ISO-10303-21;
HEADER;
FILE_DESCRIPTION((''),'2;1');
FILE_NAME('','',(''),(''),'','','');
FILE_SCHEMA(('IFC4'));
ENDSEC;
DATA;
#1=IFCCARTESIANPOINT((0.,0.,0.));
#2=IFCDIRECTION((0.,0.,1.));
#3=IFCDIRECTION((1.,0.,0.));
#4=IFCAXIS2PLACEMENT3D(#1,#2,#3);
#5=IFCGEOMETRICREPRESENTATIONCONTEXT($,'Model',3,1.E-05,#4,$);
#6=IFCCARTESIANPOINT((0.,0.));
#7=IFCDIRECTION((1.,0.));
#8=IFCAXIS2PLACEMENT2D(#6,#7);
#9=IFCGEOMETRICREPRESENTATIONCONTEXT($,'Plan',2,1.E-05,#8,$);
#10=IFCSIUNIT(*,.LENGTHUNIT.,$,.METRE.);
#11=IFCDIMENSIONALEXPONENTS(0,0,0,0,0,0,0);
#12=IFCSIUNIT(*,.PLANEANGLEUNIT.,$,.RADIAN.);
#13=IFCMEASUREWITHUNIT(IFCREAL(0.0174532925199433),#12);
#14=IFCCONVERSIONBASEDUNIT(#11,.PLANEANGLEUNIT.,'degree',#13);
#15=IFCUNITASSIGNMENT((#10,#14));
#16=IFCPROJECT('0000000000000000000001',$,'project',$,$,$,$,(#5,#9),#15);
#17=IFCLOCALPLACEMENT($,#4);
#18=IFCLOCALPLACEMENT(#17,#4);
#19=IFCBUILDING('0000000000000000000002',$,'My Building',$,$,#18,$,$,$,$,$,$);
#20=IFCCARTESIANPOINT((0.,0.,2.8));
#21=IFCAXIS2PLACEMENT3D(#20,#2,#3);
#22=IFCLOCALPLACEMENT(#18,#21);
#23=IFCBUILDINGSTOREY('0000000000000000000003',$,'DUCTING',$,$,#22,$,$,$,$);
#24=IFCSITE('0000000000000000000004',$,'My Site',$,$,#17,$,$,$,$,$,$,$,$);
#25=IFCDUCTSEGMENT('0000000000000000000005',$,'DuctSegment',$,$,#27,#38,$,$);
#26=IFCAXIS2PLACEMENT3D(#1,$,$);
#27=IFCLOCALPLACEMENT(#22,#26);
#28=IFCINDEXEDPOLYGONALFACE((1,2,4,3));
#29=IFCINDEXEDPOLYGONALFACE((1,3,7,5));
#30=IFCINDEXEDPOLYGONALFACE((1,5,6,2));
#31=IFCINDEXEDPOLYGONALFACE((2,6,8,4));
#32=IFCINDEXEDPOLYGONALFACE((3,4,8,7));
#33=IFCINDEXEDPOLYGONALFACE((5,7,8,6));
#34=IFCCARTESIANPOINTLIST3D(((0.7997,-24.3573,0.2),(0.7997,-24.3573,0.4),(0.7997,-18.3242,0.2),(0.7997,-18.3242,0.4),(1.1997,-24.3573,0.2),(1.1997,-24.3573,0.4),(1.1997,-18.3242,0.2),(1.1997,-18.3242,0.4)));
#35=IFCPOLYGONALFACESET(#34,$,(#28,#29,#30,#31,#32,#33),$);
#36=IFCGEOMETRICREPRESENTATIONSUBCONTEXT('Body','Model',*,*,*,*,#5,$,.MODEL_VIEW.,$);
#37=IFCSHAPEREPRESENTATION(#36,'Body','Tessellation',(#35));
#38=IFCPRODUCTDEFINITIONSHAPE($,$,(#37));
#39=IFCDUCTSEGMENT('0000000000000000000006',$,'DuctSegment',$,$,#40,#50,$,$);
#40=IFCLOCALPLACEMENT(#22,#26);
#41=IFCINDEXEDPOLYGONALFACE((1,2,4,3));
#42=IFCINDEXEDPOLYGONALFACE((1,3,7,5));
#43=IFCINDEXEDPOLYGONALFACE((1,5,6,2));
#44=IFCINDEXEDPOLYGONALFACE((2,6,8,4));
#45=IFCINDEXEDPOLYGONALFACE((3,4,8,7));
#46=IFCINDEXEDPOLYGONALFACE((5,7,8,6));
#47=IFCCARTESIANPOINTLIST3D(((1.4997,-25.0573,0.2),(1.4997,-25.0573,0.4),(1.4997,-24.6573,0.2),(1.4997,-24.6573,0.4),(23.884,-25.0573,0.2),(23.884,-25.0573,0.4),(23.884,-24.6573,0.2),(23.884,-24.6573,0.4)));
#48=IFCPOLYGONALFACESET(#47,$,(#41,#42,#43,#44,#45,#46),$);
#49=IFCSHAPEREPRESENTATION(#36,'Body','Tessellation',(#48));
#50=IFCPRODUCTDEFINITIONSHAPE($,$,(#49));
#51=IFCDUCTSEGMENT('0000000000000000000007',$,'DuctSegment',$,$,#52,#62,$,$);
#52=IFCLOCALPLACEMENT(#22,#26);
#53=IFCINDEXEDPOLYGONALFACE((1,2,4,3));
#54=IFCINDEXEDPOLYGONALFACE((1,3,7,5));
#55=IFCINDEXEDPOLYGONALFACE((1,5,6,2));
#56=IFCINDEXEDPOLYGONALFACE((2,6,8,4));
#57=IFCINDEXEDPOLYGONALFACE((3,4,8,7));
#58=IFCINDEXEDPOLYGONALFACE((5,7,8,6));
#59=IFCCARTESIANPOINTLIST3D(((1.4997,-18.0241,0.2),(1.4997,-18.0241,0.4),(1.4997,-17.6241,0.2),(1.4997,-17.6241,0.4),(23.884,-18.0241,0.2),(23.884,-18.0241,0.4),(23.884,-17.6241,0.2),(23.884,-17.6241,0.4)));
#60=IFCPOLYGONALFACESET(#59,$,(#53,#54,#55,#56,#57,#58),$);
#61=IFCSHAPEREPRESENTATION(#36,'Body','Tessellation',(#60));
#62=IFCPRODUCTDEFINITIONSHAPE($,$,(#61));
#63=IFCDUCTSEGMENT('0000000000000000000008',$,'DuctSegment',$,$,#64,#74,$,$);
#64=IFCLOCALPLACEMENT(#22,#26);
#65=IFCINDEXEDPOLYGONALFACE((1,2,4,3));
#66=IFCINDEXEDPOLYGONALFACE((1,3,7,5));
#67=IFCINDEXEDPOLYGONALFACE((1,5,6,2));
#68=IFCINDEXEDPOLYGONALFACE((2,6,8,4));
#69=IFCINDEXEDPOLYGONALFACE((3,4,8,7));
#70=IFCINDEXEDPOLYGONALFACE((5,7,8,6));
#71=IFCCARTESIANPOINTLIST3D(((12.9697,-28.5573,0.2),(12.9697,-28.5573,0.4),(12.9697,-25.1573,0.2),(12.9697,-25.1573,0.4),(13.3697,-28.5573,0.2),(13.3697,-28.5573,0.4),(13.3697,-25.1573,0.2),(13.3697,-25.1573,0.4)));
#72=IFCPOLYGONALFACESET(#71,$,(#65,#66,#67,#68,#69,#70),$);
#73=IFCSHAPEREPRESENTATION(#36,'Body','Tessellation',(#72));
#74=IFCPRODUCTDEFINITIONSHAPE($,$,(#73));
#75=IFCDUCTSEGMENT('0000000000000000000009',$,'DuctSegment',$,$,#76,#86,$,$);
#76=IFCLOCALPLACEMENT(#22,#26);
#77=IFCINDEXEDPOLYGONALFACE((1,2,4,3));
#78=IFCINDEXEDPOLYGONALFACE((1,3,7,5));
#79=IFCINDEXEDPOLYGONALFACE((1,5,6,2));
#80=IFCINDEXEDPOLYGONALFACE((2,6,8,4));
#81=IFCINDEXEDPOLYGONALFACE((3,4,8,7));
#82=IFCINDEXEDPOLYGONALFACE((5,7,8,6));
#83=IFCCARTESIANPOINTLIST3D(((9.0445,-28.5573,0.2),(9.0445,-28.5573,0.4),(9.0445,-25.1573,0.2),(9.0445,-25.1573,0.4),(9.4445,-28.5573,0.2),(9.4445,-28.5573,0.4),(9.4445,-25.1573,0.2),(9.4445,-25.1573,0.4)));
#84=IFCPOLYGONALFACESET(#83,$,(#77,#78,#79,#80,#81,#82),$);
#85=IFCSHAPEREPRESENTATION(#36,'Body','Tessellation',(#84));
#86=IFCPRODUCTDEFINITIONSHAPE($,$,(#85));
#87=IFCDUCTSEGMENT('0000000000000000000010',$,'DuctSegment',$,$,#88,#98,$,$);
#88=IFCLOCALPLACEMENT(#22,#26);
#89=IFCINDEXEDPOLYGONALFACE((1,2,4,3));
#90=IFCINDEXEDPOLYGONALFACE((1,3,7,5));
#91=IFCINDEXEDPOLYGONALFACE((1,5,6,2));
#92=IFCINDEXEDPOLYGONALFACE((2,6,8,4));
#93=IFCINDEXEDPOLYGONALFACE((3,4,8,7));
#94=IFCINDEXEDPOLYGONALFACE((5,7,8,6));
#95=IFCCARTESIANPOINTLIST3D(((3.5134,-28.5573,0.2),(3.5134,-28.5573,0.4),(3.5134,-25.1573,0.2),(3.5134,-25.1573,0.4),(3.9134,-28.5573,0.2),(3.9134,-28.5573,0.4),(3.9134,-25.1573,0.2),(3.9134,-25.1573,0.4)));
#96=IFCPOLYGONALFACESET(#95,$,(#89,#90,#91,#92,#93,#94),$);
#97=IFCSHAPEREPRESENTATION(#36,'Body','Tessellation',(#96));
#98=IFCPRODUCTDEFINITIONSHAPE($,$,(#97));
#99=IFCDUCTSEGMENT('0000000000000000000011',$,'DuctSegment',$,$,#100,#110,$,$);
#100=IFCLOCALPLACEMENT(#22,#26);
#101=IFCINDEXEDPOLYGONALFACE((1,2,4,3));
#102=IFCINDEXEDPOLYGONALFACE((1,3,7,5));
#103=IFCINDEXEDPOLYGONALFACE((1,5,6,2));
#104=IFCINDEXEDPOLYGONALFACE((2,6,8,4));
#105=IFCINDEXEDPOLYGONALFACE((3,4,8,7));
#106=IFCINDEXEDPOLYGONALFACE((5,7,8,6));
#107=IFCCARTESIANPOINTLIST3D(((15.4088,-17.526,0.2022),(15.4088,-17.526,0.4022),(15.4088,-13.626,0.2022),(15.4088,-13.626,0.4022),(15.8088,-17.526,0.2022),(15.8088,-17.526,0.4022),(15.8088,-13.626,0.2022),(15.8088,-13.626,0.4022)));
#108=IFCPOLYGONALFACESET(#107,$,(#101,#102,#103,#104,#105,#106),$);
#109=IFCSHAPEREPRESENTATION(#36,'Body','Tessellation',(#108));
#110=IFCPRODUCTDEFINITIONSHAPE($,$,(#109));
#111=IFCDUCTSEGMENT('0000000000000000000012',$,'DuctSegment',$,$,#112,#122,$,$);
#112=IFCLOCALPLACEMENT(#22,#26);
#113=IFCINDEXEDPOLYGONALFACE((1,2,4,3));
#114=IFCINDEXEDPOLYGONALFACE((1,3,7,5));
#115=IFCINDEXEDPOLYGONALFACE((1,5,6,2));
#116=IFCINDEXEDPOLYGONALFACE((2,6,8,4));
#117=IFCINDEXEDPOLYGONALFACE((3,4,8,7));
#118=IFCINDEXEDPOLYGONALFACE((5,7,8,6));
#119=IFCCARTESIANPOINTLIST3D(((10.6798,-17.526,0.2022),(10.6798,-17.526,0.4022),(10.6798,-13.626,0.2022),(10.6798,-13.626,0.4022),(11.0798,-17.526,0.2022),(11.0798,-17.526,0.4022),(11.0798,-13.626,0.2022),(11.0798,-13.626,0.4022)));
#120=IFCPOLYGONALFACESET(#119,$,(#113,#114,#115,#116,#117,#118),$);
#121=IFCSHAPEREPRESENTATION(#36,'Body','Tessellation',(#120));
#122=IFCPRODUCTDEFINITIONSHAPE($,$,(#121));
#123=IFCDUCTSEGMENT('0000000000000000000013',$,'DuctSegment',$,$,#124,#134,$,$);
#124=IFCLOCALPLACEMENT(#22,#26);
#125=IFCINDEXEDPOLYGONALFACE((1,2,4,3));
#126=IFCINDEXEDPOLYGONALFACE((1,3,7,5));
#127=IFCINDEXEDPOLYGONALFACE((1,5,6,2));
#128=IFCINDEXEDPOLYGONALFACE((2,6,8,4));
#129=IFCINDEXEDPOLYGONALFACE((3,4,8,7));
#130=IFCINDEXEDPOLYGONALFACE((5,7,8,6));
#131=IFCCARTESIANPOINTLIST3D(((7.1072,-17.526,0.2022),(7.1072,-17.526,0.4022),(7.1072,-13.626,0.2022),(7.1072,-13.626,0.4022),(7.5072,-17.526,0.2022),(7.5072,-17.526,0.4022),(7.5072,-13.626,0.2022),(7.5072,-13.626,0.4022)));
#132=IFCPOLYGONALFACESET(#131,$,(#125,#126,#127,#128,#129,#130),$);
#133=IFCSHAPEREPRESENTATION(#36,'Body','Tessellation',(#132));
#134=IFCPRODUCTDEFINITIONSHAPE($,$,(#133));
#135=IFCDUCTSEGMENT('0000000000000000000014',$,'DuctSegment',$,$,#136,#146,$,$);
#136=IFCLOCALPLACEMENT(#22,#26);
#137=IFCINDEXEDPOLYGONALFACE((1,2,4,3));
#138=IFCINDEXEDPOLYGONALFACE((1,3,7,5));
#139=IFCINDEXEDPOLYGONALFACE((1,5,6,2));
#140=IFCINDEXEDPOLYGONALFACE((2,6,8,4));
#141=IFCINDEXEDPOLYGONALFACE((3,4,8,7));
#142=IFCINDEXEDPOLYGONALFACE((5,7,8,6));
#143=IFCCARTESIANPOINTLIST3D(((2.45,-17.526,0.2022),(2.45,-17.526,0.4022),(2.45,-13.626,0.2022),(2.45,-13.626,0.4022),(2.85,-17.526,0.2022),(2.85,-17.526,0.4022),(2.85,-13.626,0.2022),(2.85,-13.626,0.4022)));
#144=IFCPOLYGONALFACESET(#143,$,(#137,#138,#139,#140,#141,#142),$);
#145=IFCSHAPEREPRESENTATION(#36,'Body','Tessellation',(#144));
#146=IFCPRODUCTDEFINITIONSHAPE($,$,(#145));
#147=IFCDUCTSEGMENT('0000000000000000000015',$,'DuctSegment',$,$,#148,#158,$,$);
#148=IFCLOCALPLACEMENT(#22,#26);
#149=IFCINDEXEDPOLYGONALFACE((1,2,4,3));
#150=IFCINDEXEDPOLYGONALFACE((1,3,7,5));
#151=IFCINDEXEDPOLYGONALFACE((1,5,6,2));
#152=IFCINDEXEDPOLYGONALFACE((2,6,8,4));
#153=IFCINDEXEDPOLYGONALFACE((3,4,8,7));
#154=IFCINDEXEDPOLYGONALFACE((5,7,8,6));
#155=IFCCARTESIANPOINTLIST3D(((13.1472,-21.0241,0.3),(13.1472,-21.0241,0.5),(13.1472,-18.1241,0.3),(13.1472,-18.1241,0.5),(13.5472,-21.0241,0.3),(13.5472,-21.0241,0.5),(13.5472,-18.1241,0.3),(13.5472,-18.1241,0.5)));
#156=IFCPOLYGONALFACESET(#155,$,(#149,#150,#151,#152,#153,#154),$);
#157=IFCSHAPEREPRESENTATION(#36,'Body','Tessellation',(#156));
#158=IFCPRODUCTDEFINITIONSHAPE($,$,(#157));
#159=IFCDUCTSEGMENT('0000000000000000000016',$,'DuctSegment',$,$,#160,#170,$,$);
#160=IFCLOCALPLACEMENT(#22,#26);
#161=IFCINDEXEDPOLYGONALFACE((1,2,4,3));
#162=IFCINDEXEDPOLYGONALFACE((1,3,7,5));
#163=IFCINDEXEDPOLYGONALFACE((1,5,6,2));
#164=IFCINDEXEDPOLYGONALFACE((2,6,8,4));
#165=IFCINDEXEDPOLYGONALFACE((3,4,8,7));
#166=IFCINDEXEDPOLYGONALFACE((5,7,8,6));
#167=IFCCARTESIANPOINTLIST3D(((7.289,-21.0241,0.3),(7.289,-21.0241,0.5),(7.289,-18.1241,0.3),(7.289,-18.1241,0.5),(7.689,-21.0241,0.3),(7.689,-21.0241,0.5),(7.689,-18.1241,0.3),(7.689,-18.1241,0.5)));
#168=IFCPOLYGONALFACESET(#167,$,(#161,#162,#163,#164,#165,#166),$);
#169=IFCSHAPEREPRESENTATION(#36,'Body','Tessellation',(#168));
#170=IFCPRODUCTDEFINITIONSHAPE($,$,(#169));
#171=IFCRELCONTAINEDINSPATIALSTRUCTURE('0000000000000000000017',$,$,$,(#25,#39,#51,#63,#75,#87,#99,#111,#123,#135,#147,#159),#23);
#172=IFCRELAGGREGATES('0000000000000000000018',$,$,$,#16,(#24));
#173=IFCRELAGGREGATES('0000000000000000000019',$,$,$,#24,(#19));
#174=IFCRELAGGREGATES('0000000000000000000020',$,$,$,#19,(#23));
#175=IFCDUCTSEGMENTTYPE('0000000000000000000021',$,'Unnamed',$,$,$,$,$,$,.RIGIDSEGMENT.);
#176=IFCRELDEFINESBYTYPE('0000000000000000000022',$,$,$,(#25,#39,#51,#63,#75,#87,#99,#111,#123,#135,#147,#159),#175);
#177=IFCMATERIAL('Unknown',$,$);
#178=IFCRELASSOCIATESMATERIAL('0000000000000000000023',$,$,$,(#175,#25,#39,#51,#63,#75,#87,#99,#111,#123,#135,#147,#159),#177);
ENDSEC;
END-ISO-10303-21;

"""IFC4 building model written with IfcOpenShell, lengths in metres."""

from ifc_helpers import new_model, entity, si_unit, converted_unit, frame, origin_with_axes, origin_2d_with_axis, place, context, subcontext, project, spatial, rectangle, extrude, material, material_profile, profile_set, profile_usage, type_object, element, save


model = new_model("IFC4")

# Units and contexts
model_context = context("Model", 3, precision=1e-05, world=origin_with_axes())
plan_context = context("Plan", 2, precision=1e-05, world=origin_2d_with_axis())
body_context = subcontext(model_context, "Body", "Model", "MODEL_VIEW")
ifc_project = project(units=[si_unit("LENGTHUNIT", "METRE"), converted_unit("PLANEANGLEUNIT", "degree", entity("IfcReal", 0.0174532925199433), si_unit("PLANEANGLEUNIT", "RADIAN"), dimensions=[0, 0, 0, 0, 0, 0, 0])], contexts=[model_context, plan_context])

# Site, building, storey
site_placement = place(None, origin_with_axes())
site = spatial("IfcSite", under=ifc_project, at=site_placement, Name="My Site")
building_placement = place(site_placement, origin_with_axes())
building = spatial("IfcBuilding", under=site, at=building_placement, Name="My Building")
storey_placement = place(building_placement, frame((0.0, 0.0, 2.8), z_axis=(0.0, 0.0, 1.0), x_axis=(1.0, 0.0, 0.0)))
storey = spatial("IfcBuildingStorey", under=building, at=storey_placement, Name="DUCTING")

# Duct segments
ifc_material = material(Name="Unknown")
ifc_material_profile_1 = material_profile(ifc_material, rectangle(XDim=0.4, YDim=0.2))
ifc_profile_set_1 = profile_set([ifc_material_profile_1])
ifc_profile_usage_1 = profile_usage(ifc_profile_set_1, cardinal=5)
duct_segment_type = type_object("IfcDuctSegmentType", Name="Unnamed", PredefinedType="RIGIDSEGMENT", material=ifc_profile_set_1)
duct_segment_1_placement = place(storey_placement, frame((0.9997, -18.3242, 0.3), z_axis=(0.0, -1.0, 0.0), x_axis=(1.0, 0.0, 0.0)))
element("IfcDuctSegment", 1, at=duct_segment_1_placement, inside=storey, type_object=duct_segment_type, material=ifc_profile_usage_1, Name="DuctSegment", context=body_context, shape_type="SweptSolid", body=[
    extrude(rectangle(XDim=0.4, YDim=0.2), origin_with_axes(), (0.0, 0.0, 1.0), 6.0332),
])
ifc_profile_usage_2 = profile_usage(ifc_profile_set_1, cardinal=5)
duct_segment_2_placement = place(storey_placement, frame((1.4997, -24.8573, 0.3), z_axis=(1.0, 0.0, 0.000001), x_axis=(0.0, 1.0, 0.0)))
element("IfcDuctSegment", 2, at=duct_segment_2_placement, inside=storey, type_object=duct_segment_type, material=ifc_profile_usage_2, Name="DuctSegment", context=body_context, shape_type="SweptSolid", body=[
    extrude(rectangle(XDim=0.4, YDim=0.2), origin_with_axes(), (0.0, 0.0, 1.0), 22.3843),
])
ifc_profile_usage_3 = profile_usage(ifc_profile_set_1, cardinal=5)
duct_segment_3_placement = place(storey_placement, frame((1.4997, -17.8241, 0.3), z_axis=(1.0, 0.0, 0.000001), x_axis=(0.0, 1.0, 0.0)))
element("IfcDuctSegment", 3, at=duct_segment_3_placement, inside=storey, type_object=duct_segment_type, material=ifc_profile_usage_3, Name="DuctSegment", context=body_context, shape_type="SweptSolid", body=[
    extrude(rectangle(XDim=0.4, YDim=0.2), origin_with_axes(), (0.0, 0.0, 1.0), 22.3843),
])
ifc_profile_usage_4 = profile_usage(ifc_profile_set_1, cardinal=5)
duct_segment_4_placement = place(storey_placement, frame((13.1697, -25.1573, 0.3), z_axis=(0.0, -1.0, 0.0), x_axis=(1.0, 0.0, 0.0)))
element("IfcDuctSegment", 4, at=duct_segment_4_placement, inside=storey, type_object=duct_segment_type, material=ifc_profile_usage_4, Name="DuctSegment", context=body_context, shape_type="SweptSolid", body=[
    extrude(rectangle(XDim=0.4, YDim=0.2), origin_with_axes(), (0.0, 0.0, 1.0), 3.4),
])
ifc_profile_usage_5 = profile_usage(ifc_profile_set_1, cardinal=5)
duct_segment_5_placement = place(storey_placement, frame((9.2445, -25.1573, 0.3), z_axis=(0.0, -1.0, 0.0), x_axis=(1.0, 0.0, 0.0)))
element("IfcDuctSegment", 5, at=duct_segment_5_placement, inside=storey, type_object=duct_segment_type, material=ifc_profile_usage_5, Name="DuctSegment", context=body_context, shape_type="SweptSolid", body=[
    extrude(rectangle(XDim=0.4, YDim=0.2), origin_with_axes(), (0.0, 0.0, 1.0), 3.4),
])
ifc_profile_usage_6 = profile_usage(ifc_profile_set_1, cardinal=5)
duct_segment_6_placement = place(storey_placement, frame((3.7134, -25.1573, 0.3), z_axis=(0.0, -1.0, 0.0), x_axis=(1.0, 0.0, 0.0)))
element("IfcDuctSegment", 6, at=duct_segment_6_placement, inside=storey, type_object=duct_segment_type, material=ifc_profile_usage_6, Name="DuctSegment", context=body_context, shape_type="SweptSolid", body=[
    extrude(rectangle(XDim=0.4, YDim=0.2), origin_with_axes(), (0.0, 0.0, 1.0), 3.4),
])
ifc_profile_usage_7 = profile_usage(ifc_profile_set_1, cardinal=5)
duct_segment_7_placement = place(storey_placement, frame((15.6088, -13.626, 0.3022), z_axis=(0.0, -1.0, 0.000003), x_axis=(1.0, 0.0, 0.0)))
element("IfcDuctSegment", 7, at=duct_segment_7_placement, inside=storey, type_object=duct_segment_type, material=ifc_profile_usage_7, Name="DuctSegment", context=body_context, shape_type="SweptSolid", body=[
    extrude(rectangle(XDim=0.4, YDim=0.2), origin_with_axes(), (0.0, 0.0, 1.0), 3.9),
])
ifc_profile_usage_8 = profile_usage(ifc_profile_set_1, cardinal=5)
duct_segment_8_placement = place(storey_placement, frame((10.8798, -13.626, 0.3022), z_axis=(0.0, -1.0, 0.000003), x_axis=(1.0, 0.0, 0.0)))
element("IfcDuctSegment", 8, at=duct_segment_8_placement, inside=storey, type_object=duct_segment_type, material=ifc_profile_usage_8, Name="DuctSegment", context=body_context, shape_type="SweptSolid", body=[
    extrude(rectangle(XDim=0.4, YDim=0.2), origin_with_axes(), (0.0, 0.0, 1.0), 3.9),
])
ifc_profile_usage_9 = profile_usage(ifc_profile_set_1, cardinal=5)
duct_segment_9_placement = place(storey_placement, frame((7.3072, -13.626, 0.3022), z_axis=(0.0, -1.0, 0.000003), x_axis=(1.0, 0.0, 0.0)))
element("IfcDuctSegment", 9, at=duct_segment_9_placement, inside=storey, type_object=duct_segment_type, material=ifc_profile_usage_9, Name="DuctSegment", context=body_context, shape_type="SweptSolid", body=[
    extrude(rectangle(XDim=0.4, YDim=0.2), origin_with_axes(), (0.0, 0.0, 1.0), 3.9),
])
ifc_profile_usage_10 = profile_usage(ifc_profile_set_1, cardinal=5)
duct_segment_10_placement = place(storey_placement, frame((2.65, -13.626, 0.3022), z_axis=(0.0, -1.0, 0.000003), x_axis=(1.0, 0.0, 0.0)))
element("IfcDuctSegment", 10, at=duct_segment_10_placement, inside=storey, type_object=duct_segment_type, material=ifc_profile_usage_10, Name="DuctSegment", context=body_context, shape_type="SweptSolid", body=[
    extrude(rectangle(XDim=0.4, YDim=0.2), origin_with_axes(), (0.0, 0.0, 1.0), 3.9),
])
ifc_profile_usage_11 = profile_usage(ifc_profile_set_1, cardinal=5)
duct_segment_11_placement = place(storey_placement, frame((13.3472, -18.1241, 0.4), z_axis=(0.0, -1.0, 0.000005), x_axis=(1.0, 0.0, 0.0)))
element("IfcDuctSegment", 11, at=duct_segment_11_placement, inside=storey, type_object=duct_segment_type, material=ifc_profile_usage_11, Name="DuctSegment", context=body_context, shape_type="SweptSolid", body=[
    extrude(rectangle(XDim=0.4, YDim=0.2), origin_with_axes(), (0.0, 0.0, 1.0), 2.9),
])
ifc_profile_usage_12 = profile_usage(ifc_profile_set_1, cardinal=5)
duct_segment_12_placement = place(storey_placement, frame((7.489, -18.1241, 0.4), z_axis=(0.0, -1.0, 0.000005), x_axis=(1.0, 0.0, 0.0)))
element("IfcDuctSegment", 12, at=duct_segment_12_placement, inside=storey, type_object=duct_segment_type, material=ifc_profile_usage_12, Name="DuctSegment", context=body_context, shape_type="SweptSolid", body=[
    extrude(rectangle(XDim=0.4, YDim=0.2), origin_with_axes(), (0.0, 0.0, 1.0), 2.9),
])

save(model, "model.ifc")
